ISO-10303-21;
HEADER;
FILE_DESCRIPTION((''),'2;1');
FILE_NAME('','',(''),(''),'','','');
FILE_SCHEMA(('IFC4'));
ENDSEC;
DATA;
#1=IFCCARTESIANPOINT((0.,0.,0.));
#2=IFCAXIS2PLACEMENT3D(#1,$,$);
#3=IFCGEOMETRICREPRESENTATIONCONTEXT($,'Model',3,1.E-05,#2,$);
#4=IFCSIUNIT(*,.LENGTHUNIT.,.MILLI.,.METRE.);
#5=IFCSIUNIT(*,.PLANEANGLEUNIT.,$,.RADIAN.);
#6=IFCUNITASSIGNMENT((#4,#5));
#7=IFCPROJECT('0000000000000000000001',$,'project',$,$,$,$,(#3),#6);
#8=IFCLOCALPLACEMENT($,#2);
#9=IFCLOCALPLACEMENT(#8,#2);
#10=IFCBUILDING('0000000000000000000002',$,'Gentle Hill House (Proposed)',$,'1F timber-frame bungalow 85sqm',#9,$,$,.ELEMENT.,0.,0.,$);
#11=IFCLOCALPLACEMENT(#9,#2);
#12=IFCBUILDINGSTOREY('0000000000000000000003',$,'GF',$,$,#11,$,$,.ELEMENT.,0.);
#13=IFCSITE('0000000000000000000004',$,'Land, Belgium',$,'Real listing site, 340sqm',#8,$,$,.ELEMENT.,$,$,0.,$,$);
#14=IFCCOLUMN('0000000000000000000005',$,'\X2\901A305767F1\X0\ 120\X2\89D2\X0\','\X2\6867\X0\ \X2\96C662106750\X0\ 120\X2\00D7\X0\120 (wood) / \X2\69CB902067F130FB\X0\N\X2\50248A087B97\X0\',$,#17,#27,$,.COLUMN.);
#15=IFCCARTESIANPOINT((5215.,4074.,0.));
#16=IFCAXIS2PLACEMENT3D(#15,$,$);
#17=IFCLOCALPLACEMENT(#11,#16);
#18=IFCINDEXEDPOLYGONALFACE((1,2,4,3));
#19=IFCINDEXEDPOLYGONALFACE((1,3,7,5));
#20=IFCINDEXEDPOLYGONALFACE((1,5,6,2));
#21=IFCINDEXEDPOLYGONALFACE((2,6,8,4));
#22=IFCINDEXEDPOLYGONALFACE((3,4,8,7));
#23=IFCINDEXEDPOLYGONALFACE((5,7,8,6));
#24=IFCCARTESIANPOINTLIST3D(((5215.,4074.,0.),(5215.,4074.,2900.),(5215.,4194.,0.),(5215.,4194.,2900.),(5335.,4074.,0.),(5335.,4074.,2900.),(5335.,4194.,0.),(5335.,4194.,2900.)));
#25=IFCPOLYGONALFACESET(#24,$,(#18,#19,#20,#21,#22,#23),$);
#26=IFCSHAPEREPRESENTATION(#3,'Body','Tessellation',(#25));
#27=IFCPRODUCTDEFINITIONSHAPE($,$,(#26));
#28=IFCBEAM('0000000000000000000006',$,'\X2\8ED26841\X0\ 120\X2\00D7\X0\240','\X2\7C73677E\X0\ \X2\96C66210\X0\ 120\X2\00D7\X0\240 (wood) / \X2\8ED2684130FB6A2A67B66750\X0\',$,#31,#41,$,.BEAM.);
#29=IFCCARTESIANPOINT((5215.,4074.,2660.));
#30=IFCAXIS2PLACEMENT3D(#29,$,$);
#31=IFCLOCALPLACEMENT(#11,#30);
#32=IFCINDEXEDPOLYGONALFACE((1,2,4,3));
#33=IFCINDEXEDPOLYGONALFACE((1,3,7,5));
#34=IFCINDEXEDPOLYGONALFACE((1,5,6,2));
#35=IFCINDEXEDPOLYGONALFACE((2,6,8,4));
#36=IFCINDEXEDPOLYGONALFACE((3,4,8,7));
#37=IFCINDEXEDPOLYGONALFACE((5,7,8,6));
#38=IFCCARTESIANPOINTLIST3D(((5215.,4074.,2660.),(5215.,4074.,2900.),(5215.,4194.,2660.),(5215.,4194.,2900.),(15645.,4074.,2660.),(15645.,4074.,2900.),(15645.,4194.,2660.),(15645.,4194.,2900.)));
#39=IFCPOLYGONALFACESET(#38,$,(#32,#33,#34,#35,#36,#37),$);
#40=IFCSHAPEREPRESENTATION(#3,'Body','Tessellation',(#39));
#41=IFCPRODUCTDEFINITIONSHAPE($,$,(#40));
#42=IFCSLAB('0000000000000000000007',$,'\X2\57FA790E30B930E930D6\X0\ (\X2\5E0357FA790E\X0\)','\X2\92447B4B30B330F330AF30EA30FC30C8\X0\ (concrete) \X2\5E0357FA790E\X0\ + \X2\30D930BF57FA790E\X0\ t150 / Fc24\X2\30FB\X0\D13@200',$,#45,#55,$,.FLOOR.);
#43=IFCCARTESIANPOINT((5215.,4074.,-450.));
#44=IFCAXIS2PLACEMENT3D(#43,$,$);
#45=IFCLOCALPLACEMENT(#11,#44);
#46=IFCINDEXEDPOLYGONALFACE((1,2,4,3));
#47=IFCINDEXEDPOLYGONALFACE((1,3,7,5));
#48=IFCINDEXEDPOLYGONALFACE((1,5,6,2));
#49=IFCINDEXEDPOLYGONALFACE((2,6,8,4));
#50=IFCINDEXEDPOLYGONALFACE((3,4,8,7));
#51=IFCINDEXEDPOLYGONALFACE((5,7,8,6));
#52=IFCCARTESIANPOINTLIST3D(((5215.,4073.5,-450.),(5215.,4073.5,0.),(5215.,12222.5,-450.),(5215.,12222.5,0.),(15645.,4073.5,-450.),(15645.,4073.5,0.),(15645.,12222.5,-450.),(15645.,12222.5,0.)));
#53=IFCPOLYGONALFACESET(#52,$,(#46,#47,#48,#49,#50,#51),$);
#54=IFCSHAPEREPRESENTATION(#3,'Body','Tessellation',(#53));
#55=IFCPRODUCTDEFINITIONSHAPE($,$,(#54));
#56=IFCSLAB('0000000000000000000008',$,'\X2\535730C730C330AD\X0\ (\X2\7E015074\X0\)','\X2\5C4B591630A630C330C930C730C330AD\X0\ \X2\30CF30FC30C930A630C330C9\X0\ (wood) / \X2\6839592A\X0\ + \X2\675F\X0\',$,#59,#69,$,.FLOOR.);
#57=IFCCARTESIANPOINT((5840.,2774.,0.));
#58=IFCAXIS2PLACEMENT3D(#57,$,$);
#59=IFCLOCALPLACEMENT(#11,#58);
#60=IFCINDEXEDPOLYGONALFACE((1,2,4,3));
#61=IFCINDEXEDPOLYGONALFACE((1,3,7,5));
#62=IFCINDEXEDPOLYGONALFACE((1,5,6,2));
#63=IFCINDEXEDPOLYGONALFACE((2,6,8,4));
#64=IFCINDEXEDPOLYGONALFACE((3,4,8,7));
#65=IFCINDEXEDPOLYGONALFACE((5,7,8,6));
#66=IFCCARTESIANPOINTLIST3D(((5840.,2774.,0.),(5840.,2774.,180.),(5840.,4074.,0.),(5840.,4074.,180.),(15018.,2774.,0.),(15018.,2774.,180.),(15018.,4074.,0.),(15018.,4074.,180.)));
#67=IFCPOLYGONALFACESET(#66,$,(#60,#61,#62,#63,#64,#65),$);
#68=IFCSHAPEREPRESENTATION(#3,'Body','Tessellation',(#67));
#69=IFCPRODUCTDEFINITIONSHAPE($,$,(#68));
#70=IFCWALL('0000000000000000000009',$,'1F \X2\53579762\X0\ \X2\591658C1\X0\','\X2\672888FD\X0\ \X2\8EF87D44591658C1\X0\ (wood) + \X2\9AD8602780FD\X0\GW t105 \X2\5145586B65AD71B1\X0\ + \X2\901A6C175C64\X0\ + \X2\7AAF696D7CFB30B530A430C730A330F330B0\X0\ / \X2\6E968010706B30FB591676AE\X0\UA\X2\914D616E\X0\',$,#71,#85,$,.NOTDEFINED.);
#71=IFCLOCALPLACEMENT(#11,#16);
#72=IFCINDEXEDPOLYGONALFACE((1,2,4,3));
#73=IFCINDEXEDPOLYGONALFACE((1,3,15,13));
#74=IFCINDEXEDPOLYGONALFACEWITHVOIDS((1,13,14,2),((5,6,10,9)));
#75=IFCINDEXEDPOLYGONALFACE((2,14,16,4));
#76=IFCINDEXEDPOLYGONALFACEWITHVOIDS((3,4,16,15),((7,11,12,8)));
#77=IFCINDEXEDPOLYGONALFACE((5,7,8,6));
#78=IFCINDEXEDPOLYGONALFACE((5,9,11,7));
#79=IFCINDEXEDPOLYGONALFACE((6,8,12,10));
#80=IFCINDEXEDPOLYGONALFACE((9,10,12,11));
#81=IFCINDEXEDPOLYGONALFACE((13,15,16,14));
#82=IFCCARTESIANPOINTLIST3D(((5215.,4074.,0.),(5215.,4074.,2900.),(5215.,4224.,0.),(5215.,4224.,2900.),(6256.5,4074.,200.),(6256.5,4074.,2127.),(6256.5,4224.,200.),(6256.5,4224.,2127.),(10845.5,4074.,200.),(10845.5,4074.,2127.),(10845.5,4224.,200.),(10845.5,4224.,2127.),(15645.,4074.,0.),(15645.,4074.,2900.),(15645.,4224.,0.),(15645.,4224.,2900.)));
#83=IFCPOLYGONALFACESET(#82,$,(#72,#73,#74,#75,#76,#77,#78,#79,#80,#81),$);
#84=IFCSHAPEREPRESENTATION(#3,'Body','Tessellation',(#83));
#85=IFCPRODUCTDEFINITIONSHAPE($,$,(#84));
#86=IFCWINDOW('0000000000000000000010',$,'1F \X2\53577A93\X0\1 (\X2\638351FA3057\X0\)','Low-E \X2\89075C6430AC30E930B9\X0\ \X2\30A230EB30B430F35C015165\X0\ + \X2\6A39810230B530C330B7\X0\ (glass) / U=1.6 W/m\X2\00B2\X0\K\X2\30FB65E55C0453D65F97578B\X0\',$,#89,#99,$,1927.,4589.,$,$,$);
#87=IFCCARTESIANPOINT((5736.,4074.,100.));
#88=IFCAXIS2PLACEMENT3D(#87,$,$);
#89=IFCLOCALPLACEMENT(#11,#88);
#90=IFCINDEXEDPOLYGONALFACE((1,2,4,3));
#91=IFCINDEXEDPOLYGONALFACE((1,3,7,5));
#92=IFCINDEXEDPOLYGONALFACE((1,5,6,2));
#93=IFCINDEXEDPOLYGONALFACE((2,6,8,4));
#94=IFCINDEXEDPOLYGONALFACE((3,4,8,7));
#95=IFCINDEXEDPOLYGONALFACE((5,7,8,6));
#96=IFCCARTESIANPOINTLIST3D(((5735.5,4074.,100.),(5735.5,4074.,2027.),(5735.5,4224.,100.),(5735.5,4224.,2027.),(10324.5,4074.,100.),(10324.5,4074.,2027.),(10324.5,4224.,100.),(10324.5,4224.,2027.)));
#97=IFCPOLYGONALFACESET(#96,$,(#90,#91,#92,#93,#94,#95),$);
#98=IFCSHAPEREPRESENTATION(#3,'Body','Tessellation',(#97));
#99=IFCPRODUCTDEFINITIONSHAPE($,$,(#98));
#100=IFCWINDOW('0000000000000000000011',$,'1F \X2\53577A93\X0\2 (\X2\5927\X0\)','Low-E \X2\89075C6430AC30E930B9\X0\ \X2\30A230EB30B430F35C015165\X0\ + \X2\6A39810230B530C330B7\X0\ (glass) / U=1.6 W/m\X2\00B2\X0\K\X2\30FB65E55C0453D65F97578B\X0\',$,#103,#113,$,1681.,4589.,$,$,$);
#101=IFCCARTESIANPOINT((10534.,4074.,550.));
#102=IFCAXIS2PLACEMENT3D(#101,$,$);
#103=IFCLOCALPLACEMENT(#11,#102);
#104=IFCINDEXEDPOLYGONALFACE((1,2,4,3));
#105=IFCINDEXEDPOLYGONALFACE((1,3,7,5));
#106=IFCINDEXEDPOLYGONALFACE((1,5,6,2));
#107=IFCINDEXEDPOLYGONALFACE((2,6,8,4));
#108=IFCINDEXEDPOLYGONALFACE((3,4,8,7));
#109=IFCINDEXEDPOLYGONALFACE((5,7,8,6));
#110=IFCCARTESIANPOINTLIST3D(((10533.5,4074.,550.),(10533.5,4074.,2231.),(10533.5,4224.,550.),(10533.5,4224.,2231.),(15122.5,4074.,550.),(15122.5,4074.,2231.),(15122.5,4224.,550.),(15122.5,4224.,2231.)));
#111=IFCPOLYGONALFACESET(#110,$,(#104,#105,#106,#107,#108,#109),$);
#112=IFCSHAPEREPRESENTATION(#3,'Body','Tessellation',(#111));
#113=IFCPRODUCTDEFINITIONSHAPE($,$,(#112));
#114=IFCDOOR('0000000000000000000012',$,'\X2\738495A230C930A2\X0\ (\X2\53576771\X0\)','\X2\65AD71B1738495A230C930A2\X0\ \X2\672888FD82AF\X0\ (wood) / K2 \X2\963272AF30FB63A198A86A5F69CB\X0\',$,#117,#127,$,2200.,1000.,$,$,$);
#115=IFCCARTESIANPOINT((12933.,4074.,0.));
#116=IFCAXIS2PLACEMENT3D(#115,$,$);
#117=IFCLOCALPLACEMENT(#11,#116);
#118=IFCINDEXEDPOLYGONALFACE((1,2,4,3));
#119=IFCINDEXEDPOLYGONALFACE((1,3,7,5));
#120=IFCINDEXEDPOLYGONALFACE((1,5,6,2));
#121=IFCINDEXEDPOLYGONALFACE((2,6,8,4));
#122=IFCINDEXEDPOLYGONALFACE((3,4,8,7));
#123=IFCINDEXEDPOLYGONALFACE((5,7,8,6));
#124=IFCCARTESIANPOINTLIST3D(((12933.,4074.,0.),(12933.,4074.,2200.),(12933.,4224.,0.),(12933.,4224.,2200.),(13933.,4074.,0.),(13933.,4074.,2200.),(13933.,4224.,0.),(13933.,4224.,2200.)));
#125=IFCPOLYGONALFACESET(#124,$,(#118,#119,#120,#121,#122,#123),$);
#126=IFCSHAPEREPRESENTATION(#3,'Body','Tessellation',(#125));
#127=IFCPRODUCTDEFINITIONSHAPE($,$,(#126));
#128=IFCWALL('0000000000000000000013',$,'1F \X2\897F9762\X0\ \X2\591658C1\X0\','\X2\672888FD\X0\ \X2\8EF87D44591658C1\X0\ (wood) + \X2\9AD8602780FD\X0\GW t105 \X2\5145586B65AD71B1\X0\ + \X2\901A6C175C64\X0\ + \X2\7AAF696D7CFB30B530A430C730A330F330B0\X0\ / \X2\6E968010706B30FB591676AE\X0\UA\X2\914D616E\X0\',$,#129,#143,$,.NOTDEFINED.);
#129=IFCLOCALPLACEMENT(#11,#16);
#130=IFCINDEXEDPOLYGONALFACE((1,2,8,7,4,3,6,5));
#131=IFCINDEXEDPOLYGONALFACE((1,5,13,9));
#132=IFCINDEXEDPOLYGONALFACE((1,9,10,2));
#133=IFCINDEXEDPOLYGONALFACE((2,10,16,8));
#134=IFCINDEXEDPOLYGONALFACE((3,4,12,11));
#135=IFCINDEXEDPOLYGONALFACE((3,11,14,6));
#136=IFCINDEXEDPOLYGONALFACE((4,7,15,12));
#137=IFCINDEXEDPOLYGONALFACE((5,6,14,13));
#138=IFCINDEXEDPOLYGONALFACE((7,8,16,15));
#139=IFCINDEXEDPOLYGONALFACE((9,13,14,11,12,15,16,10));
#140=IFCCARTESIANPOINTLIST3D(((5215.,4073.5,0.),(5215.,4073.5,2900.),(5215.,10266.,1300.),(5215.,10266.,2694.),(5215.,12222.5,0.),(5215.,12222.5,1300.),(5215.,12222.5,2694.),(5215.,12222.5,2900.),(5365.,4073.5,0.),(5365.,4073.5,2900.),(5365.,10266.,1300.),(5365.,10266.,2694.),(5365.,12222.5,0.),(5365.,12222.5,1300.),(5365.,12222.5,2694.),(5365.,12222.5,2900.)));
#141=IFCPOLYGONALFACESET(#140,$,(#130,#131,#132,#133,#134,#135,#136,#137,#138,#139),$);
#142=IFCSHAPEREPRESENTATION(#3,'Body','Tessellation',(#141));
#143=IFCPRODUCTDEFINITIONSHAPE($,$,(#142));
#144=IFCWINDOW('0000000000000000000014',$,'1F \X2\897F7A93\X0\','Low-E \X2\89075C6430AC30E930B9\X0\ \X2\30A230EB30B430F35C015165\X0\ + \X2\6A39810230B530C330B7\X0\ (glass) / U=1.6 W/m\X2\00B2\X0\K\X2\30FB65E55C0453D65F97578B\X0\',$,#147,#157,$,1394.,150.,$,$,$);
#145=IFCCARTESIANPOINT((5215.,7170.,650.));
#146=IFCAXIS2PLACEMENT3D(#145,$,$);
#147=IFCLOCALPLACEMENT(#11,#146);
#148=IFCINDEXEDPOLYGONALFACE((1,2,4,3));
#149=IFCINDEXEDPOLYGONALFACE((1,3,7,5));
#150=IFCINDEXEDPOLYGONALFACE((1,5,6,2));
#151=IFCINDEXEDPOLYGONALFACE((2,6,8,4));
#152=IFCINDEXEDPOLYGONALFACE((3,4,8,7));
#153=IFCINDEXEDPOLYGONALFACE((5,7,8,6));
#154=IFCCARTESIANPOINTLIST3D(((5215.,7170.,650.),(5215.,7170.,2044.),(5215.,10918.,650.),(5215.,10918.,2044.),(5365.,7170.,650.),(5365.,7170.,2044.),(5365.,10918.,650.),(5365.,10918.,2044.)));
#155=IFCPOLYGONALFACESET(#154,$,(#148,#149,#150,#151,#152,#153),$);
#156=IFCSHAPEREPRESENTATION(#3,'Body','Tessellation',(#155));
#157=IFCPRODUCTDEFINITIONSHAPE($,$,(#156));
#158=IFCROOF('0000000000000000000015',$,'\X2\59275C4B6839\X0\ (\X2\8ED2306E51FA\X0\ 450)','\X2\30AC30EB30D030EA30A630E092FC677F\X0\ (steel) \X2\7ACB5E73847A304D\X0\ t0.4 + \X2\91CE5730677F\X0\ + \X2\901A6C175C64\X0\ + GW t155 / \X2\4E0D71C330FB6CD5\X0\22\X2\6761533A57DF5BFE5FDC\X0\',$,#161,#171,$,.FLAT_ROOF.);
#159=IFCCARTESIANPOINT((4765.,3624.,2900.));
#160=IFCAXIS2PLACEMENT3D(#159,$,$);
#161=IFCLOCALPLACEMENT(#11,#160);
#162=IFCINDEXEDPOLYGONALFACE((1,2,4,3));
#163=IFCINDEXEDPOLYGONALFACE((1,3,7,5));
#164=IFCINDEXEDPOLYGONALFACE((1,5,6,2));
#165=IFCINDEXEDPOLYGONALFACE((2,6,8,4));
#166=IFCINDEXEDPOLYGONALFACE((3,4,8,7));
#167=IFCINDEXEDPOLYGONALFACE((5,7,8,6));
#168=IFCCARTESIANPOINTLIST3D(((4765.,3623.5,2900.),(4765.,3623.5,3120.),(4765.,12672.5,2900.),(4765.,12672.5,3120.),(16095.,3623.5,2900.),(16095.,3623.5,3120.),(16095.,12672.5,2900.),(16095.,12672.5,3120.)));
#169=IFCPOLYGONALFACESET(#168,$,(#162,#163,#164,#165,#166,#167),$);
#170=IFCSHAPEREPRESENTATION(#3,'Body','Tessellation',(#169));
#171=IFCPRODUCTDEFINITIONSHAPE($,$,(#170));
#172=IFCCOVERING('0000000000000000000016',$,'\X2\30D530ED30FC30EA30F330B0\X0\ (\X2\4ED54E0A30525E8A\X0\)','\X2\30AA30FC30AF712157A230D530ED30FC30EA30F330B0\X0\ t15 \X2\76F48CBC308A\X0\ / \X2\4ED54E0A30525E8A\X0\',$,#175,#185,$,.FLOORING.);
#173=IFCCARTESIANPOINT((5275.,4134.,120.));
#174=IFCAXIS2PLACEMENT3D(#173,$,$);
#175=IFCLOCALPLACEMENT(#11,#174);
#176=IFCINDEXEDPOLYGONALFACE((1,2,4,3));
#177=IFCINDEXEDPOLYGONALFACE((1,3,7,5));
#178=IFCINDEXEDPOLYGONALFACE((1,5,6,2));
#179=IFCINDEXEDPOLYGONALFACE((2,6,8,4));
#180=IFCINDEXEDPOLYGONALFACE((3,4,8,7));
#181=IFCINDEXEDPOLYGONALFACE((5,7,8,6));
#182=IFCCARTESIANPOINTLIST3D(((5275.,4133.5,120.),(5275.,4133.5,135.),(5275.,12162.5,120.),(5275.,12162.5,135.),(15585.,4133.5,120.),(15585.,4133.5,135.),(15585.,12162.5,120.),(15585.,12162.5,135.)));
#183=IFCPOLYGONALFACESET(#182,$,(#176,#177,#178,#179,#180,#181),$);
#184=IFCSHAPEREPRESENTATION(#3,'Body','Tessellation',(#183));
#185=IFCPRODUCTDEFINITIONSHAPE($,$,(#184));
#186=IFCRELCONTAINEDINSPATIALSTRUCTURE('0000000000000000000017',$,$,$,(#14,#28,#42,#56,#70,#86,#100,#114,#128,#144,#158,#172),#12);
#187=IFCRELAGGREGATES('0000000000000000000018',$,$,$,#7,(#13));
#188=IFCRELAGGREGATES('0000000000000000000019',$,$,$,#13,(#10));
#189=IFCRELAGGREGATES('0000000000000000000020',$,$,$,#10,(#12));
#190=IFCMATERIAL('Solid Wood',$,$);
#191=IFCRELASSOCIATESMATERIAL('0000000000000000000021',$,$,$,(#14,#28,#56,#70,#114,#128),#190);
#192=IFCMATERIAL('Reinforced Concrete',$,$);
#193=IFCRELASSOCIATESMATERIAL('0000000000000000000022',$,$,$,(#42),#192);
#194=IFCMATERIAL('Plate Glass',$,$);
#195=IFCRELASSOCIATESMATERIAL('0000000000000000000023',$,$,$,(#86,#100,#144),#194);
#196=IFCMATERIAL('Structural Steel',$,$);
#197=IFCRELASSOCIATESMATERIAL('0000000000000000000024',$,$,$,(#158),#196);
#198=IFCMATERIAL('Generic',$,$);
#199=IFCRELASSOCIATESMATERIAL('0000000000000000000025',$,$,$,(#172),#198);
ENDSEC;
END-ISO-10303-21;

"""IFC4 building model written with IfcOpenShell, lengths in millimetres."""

from ifc_helpers import new_model, si_unit, frame, frame_2d, origin, place, context, project, spatial, rectangle, extrude, material, element, fill, save


model = new_model("IFC4")

# Units and contexts
model_context = context("Model", 3, precision=1e-05, world=origin())
ifc_project = project(units=[si_unit("LENGTHUNIT", "METRE", prefix="MILLI"), si_unit("PLANEANGLEUNIT", "RADIAN")], contexts=[model_context])

# Site, building, storey
site_placement = place(None, origin())
site = spatial("IfcSite", under=ifc_project, at=site_placement, Name="Land, Belgium", ObjectType="Real listing site, 340sqm", CompositionType="ELEMENT", RefElevation=0.0)
building_placement = place(site_placement, origin())
building = spatial("IfcBuilding", under=site, at=building_placement, Name="Gentle Hill House (Proposed)", ObjectType="1F timber-frame bungalow 85sqm", CompositionType="ELEMENT", ElevationOfRefHeight=0.0, ElevationOfTerrain=0.0)
storey_placement = place(building_placement, origin())
storey = spatial("IfcBuildingStorey", under=building, at=storey_placement, Name="GF", CompositionType="ELEMENT", Elevation=0.0)

# Column
ifc_material_1 = material(Name="Solid Wood")
column_placement = place(storey_placement, frame((5215.0, 4074.0, 0.0)))
element("IfcColumn", 1, at=column_placement, inside=storey, material=ifc_material_1, Name="通し柱 120角", Description="桧 集成材 120×120 (wood) / 構造柱・N値計算", PredefinedType="COLUMN", context=model_context, shape_type="SweptSolid", body=[
    extrude(rectangle(XDim=120.0, YDim=120.0, at=frame_2d((60.0, 60.0))), frame((5215.0, 4074.0, 0.0)), (0.0, 0.0, 1.0), 2900.0),
])

# Beam
beam_1_placement = place(storey_placement, frame((5215.0, 4074.0, 2660.0)))
element("IfcBeam", 2, at=beam_1_placement, inside=storey, material=ifc_material_1, Name="軒桁 120×240", Description="米松 集成 120×240 (wood) / 軒桁・横架材", PredefinedType="BEAM", context=model_context, shape_type="SweptSolid", body=[
    extrude(rectangle(XDim=10430.0, YDim=120.0, at=frame_2d((5215.0, 60.0))), frame((5215.0, 4074.0, 2660.0)), (0.0, 0.0, 1.0), 240.0),
])

# Slabs
ifc_material_2 = material(Name="Reinforced Concrete")
slab_1_placement = place(storey_placement, frame((5215.0, 4074.0, -450.0)))
element("IfcSlab", 3, at=slab_1_placement, inside=storey, material=ifc_material_2, Name="基礎スラブ (布基礎)", Description="鉄筋コンクリート (concrete) 布基礎 + ベタ基礎 t150 / Fc24・D13@200", PredefinedType="FLOOR", context=model_context, shape_type="SweptSolid", body=[
    extrude(rectangle(XDim=10430.0, YDim=8149.0, at=frame_2d((5215.0, 4074.0))), frame((5215.0, 4074.0, -450.0)), (0.0, 0.0, 1.0), 450.0),
])
slab_2_placement = place(storey_placement, frame((5840.0, 2774.0, 0.0)))
element("IfcSlab", 4, at=slab_2_placement, inside=storey, material=ifc_material_1, Name="南デッキ (縁側)", Description="屋外ウッドデッキ ハードウッド (wood) / 根太 + 束", PredefinedType="FLOOR", context=model_context, shape_type="SweptSolid", body=[
    extrude(rectangle(XDim=9178.0, YDim=1300.0, at=frame_2d((4589.0, 650.0))), frame((5840.0, 2774.0, 0.0)), (0.0, 0.0, 1.0), 180.0),
])

# Wall, openings, windows, door
wall_1_placement = place(storey_placement, frame((5215.0, 4074.0, 0.0)))
wall_1 = element("IfcWall", 5, at=wall_1_placement, inside=storey, material=ifc_material_1, Name="1F 南面 外壁", Description="木製 軸組外壁 (wood) + 高性能GW t105 充填断熱 + 通気層 + 窯業系サイディング / 準耐火・外皮UA配慮", PredefinedType="NOTDEFINED", context=model_context, shape_type="SweptSolid", body=[
    extrude(rectangle(XDim=10430.0, YDim=150.0, at=frame_2d((5215.0, 75.0))), frame((5215.0, 4074.0, 0.0)), (0.0, 0.0, 1.0), 2900.0),
])
opening_1_placement = place(storey_placement, frame((5736.0, 4074.0, 100.0)))
opening_1 = element("IfcOpeningElement", 6, at=opening_1_placement, cuts=wall_1, PredefinedType="NOTDEFINED", context=model_context, shape_type="SweptSolid", body=[
    extrude(rectangle(XDim=4589.0, YDim=150.0, at=frame_2d((2294.0, 75.0))), frame((5736.0, 4074.0, 100.0)), (0.0, 0.0, 1.0), 1927.0),
])
opening_2_placement = place(storey_placement, frame((10534.0, 4074.0, 550.0)))
opening_2 = element("IfcOpeningElement", 7, at=opening_2_placement, cuts=wall_1, PredefinedType="NOTDEFINED", context=model_context, shape_type="SweptSolid", body=[
    extrude(rectangle(XDim=4589.0, YDim=150.0, at=frame_2d((2294.0, 75.0))), frame((10534.0, 4074.0, 550.0)), (0.0, 0.0, 1.0), 1681.0),
])
opening_3_placement = place(storey_placement, frame((12933.0, 4074.0, 0.0)))
opening_3 = element("IfcOpeningElement", 8, at=opening_3_placement, cuts=wall_1, PredefinedType="NOTDEFINED", context=model_context, shape_type="SweptSolid", body=[
    extrude(rectangle(XDim=1000.0, YDim=150.0, at=frame_2d((500.0, 75.0))), frame((12933.0, 4074.0, 0.0)), (0.0, 0.0, 1.0), 2200.0),
])
ifc_material_3 = material(Name="Plate Glass")
window_1_placement = place(storey_placement, frame((5736.0, 4074.0, 100.0)))
window_1 = element("IfcWindow", 9, at=window_1_placement, inside=storey, material=ifc_material_3, Name="1F 南窓1 (掃出し)", Description="Low-E 複層ガラス アルゴン封入 + 樹脂サッシ (glass) / U=1.6 W/m²K・日射取得型", OverallHeight=1927.0, OverallWidth=4589.0, context=model_context, shape_type="SweptSolid", body=[
    extrude(rectangle(XDim=4589.0, YDim=150.0, at=frame_2d((2294.0, 75.0))), frame((5736.0, 4074.0, 100.0)), (0.0, 0.0, 1.0), 1927.0),
])
fill(opening_1, window_1)
window_2_placement = place(storey_placement, frame((10534.0, 4074.0, 550.0)))
window_2 = element("IfcWindow", 10, at=window_2_placement, inside=storey, material=ifc_material_3, Name="1F 南窓2 (大)", Description="Low-E 複層ガラス アルゴン封入 + 樹脂サッシ (glass) / U=1.6 W/m²K・日射取得型", OverallHeight=1681.0, OverallWidth=4589.0, context=model_context, shape_type="SweptSolid", body=[
    extrude(rectangle(XDim=4589.0, YDim=150.0, at=frame_2d((2294.0, 75.0))), frame((10534.0, 4074.0, 550.0)), (0.0, 0.0, 1.0), 1681.0),
])
fill(opening_2, window_2)
door_placement = place(storey_placement, frame((12933.0, 4074.0, 0.0)))
door = element("IfcDoor", 11, at=door_placement, inside=storey, material=ifc_material_1, Name="玄関ドア (南東)", Description="断熱玄関ドア 木製芯 (wood) / K2 防犯・採風機構", OverallHeight=2200.0, OverallWidth=1000.0, context=model_context, shape_type="SweptSolid", body=[
    extrude(rectangle(XDim=1000.0, YDim=150.0, at=frame_2d((500.0, 75.0))), frame((12933.0, 4074.0, 0.0)), (0.0, 0.0, 1.0), 2200.0),
])
fill(opening_3, door)

# Wall, opening, window
wall_2_placement = place(storey_placement, frame((5215.0, 4074.0, 0.0)))
wall_2 = element("IfcWall", 12, at=wall_2_placement, inside=storey, material=ifc_material_1, Name="1F 西面 外壁", Description="木製 軸組外壁 (wood) + 高性能GW t105 充填断熱 + 通気層 + 窯業系サイディング / 準耐火・外皮UA配慮", PredefinedType="NOTDEFINED", context=model_context, shape_type="SweptSolid", body=[
    extrude(rectangle(XDim=150.0, YDim=8149.0, at=frame_2d((75.0, 4074.0))), frame((5215.0, 4074.0, 0.0)), (0.0, 0.0, 1.0), 2900.0),
])
opening_4_placement = place(storey_placement, frame((5215.0, 7170.0, 650.0)))
opening_4 = element("IfcOpeningElement", 13, at=opening_4_placement, cuts=wall_2, PredefinedType="NOTDEFINED", context=model_context, shape_type="SweptSolid", body=[
    extrude(rectangle(XDim=150.0, YDim=3748.0, at=frame_2d((75.0, 1874.0))), frame((5215.0, 7170.0, 650.0)), (0.0, 0.0, 1.0), 1394.0),
])
window_3_placement = place(storey_placement, frame((5215.0, 7170.0, 650.0)))
window_3 = element("IfcWindow", 14, at=window_3_placement, inside=storey, material=ifc_material_3, Name="1F 西窓", Description="Low-E 複層ガラス アルゴン封入 + 樹脂サッシ (glass) / U=1.6 W/m²K・日射取得型", OverallHeight=1394.0, OverallWidth=150.0, context=model_context, shape_type="SweptSolid", body=[
    extrude(rectangle(XDim=150.0, YDim=3748.0, at=frame_2d((75.0, 1874.0))), frame((5215.0, 7170.0, 650.0)), (0.0, 0.0, 1.0), 1394.0),
])
fill(opening_4, window_3)

# Roof
ifc_material_4 = material(Name="Structural Steel")
roof_placement = place(storey_placement, frame((4765.0, 3624.0, 2900.0)))
element("IfcRoof", 15, at=roof_placement, inside=storey, material=ifc_material_4, Name="大屋根 (軒の出 450)", Description="ガルバリウム鋼板 (steel) 立平葺き t0.4 + 野地板 + 通気層 + GW t155 / 不燃・法22条区域対応", PredefinedType="FLAT_ROOF", context=model_context, shape_type="SweptSolid", body=[
    extrude(rectangle(XDim=11330.0, YDim=9049.0, at=frame_2d((5665.0, 4524.0))), frame((4765.0, 3624.0, 2900.0)), (0.0, 0.0, 1.0), 220.0),
])

# Covering
ifc_material_5 = material(Name="Generic")
covering_1_placement = place(storey_placement, frame((5275.0, 4134.0, 120.0)))
element("IfcCovering", 16, at=covering_1_placement, inside=storey, material=ifc_material_5, Name="フローリング (仕上げ床)", Description="オーク無垢フローリング t15 直貼り / 仕上げ床", PredefinedType="FLOORING", context=model_context, shape_type="SweptSolid", body=[
    extrude(rectangle(XDim=10310.0, YDim=8029.0, at=frame_2d((5155.0, 4014.0))), frame((5275.0, 4134.0, 120.0)), (0.0, 0.0, 1.0), 15.0),
])

save(model, "model.ifc")
